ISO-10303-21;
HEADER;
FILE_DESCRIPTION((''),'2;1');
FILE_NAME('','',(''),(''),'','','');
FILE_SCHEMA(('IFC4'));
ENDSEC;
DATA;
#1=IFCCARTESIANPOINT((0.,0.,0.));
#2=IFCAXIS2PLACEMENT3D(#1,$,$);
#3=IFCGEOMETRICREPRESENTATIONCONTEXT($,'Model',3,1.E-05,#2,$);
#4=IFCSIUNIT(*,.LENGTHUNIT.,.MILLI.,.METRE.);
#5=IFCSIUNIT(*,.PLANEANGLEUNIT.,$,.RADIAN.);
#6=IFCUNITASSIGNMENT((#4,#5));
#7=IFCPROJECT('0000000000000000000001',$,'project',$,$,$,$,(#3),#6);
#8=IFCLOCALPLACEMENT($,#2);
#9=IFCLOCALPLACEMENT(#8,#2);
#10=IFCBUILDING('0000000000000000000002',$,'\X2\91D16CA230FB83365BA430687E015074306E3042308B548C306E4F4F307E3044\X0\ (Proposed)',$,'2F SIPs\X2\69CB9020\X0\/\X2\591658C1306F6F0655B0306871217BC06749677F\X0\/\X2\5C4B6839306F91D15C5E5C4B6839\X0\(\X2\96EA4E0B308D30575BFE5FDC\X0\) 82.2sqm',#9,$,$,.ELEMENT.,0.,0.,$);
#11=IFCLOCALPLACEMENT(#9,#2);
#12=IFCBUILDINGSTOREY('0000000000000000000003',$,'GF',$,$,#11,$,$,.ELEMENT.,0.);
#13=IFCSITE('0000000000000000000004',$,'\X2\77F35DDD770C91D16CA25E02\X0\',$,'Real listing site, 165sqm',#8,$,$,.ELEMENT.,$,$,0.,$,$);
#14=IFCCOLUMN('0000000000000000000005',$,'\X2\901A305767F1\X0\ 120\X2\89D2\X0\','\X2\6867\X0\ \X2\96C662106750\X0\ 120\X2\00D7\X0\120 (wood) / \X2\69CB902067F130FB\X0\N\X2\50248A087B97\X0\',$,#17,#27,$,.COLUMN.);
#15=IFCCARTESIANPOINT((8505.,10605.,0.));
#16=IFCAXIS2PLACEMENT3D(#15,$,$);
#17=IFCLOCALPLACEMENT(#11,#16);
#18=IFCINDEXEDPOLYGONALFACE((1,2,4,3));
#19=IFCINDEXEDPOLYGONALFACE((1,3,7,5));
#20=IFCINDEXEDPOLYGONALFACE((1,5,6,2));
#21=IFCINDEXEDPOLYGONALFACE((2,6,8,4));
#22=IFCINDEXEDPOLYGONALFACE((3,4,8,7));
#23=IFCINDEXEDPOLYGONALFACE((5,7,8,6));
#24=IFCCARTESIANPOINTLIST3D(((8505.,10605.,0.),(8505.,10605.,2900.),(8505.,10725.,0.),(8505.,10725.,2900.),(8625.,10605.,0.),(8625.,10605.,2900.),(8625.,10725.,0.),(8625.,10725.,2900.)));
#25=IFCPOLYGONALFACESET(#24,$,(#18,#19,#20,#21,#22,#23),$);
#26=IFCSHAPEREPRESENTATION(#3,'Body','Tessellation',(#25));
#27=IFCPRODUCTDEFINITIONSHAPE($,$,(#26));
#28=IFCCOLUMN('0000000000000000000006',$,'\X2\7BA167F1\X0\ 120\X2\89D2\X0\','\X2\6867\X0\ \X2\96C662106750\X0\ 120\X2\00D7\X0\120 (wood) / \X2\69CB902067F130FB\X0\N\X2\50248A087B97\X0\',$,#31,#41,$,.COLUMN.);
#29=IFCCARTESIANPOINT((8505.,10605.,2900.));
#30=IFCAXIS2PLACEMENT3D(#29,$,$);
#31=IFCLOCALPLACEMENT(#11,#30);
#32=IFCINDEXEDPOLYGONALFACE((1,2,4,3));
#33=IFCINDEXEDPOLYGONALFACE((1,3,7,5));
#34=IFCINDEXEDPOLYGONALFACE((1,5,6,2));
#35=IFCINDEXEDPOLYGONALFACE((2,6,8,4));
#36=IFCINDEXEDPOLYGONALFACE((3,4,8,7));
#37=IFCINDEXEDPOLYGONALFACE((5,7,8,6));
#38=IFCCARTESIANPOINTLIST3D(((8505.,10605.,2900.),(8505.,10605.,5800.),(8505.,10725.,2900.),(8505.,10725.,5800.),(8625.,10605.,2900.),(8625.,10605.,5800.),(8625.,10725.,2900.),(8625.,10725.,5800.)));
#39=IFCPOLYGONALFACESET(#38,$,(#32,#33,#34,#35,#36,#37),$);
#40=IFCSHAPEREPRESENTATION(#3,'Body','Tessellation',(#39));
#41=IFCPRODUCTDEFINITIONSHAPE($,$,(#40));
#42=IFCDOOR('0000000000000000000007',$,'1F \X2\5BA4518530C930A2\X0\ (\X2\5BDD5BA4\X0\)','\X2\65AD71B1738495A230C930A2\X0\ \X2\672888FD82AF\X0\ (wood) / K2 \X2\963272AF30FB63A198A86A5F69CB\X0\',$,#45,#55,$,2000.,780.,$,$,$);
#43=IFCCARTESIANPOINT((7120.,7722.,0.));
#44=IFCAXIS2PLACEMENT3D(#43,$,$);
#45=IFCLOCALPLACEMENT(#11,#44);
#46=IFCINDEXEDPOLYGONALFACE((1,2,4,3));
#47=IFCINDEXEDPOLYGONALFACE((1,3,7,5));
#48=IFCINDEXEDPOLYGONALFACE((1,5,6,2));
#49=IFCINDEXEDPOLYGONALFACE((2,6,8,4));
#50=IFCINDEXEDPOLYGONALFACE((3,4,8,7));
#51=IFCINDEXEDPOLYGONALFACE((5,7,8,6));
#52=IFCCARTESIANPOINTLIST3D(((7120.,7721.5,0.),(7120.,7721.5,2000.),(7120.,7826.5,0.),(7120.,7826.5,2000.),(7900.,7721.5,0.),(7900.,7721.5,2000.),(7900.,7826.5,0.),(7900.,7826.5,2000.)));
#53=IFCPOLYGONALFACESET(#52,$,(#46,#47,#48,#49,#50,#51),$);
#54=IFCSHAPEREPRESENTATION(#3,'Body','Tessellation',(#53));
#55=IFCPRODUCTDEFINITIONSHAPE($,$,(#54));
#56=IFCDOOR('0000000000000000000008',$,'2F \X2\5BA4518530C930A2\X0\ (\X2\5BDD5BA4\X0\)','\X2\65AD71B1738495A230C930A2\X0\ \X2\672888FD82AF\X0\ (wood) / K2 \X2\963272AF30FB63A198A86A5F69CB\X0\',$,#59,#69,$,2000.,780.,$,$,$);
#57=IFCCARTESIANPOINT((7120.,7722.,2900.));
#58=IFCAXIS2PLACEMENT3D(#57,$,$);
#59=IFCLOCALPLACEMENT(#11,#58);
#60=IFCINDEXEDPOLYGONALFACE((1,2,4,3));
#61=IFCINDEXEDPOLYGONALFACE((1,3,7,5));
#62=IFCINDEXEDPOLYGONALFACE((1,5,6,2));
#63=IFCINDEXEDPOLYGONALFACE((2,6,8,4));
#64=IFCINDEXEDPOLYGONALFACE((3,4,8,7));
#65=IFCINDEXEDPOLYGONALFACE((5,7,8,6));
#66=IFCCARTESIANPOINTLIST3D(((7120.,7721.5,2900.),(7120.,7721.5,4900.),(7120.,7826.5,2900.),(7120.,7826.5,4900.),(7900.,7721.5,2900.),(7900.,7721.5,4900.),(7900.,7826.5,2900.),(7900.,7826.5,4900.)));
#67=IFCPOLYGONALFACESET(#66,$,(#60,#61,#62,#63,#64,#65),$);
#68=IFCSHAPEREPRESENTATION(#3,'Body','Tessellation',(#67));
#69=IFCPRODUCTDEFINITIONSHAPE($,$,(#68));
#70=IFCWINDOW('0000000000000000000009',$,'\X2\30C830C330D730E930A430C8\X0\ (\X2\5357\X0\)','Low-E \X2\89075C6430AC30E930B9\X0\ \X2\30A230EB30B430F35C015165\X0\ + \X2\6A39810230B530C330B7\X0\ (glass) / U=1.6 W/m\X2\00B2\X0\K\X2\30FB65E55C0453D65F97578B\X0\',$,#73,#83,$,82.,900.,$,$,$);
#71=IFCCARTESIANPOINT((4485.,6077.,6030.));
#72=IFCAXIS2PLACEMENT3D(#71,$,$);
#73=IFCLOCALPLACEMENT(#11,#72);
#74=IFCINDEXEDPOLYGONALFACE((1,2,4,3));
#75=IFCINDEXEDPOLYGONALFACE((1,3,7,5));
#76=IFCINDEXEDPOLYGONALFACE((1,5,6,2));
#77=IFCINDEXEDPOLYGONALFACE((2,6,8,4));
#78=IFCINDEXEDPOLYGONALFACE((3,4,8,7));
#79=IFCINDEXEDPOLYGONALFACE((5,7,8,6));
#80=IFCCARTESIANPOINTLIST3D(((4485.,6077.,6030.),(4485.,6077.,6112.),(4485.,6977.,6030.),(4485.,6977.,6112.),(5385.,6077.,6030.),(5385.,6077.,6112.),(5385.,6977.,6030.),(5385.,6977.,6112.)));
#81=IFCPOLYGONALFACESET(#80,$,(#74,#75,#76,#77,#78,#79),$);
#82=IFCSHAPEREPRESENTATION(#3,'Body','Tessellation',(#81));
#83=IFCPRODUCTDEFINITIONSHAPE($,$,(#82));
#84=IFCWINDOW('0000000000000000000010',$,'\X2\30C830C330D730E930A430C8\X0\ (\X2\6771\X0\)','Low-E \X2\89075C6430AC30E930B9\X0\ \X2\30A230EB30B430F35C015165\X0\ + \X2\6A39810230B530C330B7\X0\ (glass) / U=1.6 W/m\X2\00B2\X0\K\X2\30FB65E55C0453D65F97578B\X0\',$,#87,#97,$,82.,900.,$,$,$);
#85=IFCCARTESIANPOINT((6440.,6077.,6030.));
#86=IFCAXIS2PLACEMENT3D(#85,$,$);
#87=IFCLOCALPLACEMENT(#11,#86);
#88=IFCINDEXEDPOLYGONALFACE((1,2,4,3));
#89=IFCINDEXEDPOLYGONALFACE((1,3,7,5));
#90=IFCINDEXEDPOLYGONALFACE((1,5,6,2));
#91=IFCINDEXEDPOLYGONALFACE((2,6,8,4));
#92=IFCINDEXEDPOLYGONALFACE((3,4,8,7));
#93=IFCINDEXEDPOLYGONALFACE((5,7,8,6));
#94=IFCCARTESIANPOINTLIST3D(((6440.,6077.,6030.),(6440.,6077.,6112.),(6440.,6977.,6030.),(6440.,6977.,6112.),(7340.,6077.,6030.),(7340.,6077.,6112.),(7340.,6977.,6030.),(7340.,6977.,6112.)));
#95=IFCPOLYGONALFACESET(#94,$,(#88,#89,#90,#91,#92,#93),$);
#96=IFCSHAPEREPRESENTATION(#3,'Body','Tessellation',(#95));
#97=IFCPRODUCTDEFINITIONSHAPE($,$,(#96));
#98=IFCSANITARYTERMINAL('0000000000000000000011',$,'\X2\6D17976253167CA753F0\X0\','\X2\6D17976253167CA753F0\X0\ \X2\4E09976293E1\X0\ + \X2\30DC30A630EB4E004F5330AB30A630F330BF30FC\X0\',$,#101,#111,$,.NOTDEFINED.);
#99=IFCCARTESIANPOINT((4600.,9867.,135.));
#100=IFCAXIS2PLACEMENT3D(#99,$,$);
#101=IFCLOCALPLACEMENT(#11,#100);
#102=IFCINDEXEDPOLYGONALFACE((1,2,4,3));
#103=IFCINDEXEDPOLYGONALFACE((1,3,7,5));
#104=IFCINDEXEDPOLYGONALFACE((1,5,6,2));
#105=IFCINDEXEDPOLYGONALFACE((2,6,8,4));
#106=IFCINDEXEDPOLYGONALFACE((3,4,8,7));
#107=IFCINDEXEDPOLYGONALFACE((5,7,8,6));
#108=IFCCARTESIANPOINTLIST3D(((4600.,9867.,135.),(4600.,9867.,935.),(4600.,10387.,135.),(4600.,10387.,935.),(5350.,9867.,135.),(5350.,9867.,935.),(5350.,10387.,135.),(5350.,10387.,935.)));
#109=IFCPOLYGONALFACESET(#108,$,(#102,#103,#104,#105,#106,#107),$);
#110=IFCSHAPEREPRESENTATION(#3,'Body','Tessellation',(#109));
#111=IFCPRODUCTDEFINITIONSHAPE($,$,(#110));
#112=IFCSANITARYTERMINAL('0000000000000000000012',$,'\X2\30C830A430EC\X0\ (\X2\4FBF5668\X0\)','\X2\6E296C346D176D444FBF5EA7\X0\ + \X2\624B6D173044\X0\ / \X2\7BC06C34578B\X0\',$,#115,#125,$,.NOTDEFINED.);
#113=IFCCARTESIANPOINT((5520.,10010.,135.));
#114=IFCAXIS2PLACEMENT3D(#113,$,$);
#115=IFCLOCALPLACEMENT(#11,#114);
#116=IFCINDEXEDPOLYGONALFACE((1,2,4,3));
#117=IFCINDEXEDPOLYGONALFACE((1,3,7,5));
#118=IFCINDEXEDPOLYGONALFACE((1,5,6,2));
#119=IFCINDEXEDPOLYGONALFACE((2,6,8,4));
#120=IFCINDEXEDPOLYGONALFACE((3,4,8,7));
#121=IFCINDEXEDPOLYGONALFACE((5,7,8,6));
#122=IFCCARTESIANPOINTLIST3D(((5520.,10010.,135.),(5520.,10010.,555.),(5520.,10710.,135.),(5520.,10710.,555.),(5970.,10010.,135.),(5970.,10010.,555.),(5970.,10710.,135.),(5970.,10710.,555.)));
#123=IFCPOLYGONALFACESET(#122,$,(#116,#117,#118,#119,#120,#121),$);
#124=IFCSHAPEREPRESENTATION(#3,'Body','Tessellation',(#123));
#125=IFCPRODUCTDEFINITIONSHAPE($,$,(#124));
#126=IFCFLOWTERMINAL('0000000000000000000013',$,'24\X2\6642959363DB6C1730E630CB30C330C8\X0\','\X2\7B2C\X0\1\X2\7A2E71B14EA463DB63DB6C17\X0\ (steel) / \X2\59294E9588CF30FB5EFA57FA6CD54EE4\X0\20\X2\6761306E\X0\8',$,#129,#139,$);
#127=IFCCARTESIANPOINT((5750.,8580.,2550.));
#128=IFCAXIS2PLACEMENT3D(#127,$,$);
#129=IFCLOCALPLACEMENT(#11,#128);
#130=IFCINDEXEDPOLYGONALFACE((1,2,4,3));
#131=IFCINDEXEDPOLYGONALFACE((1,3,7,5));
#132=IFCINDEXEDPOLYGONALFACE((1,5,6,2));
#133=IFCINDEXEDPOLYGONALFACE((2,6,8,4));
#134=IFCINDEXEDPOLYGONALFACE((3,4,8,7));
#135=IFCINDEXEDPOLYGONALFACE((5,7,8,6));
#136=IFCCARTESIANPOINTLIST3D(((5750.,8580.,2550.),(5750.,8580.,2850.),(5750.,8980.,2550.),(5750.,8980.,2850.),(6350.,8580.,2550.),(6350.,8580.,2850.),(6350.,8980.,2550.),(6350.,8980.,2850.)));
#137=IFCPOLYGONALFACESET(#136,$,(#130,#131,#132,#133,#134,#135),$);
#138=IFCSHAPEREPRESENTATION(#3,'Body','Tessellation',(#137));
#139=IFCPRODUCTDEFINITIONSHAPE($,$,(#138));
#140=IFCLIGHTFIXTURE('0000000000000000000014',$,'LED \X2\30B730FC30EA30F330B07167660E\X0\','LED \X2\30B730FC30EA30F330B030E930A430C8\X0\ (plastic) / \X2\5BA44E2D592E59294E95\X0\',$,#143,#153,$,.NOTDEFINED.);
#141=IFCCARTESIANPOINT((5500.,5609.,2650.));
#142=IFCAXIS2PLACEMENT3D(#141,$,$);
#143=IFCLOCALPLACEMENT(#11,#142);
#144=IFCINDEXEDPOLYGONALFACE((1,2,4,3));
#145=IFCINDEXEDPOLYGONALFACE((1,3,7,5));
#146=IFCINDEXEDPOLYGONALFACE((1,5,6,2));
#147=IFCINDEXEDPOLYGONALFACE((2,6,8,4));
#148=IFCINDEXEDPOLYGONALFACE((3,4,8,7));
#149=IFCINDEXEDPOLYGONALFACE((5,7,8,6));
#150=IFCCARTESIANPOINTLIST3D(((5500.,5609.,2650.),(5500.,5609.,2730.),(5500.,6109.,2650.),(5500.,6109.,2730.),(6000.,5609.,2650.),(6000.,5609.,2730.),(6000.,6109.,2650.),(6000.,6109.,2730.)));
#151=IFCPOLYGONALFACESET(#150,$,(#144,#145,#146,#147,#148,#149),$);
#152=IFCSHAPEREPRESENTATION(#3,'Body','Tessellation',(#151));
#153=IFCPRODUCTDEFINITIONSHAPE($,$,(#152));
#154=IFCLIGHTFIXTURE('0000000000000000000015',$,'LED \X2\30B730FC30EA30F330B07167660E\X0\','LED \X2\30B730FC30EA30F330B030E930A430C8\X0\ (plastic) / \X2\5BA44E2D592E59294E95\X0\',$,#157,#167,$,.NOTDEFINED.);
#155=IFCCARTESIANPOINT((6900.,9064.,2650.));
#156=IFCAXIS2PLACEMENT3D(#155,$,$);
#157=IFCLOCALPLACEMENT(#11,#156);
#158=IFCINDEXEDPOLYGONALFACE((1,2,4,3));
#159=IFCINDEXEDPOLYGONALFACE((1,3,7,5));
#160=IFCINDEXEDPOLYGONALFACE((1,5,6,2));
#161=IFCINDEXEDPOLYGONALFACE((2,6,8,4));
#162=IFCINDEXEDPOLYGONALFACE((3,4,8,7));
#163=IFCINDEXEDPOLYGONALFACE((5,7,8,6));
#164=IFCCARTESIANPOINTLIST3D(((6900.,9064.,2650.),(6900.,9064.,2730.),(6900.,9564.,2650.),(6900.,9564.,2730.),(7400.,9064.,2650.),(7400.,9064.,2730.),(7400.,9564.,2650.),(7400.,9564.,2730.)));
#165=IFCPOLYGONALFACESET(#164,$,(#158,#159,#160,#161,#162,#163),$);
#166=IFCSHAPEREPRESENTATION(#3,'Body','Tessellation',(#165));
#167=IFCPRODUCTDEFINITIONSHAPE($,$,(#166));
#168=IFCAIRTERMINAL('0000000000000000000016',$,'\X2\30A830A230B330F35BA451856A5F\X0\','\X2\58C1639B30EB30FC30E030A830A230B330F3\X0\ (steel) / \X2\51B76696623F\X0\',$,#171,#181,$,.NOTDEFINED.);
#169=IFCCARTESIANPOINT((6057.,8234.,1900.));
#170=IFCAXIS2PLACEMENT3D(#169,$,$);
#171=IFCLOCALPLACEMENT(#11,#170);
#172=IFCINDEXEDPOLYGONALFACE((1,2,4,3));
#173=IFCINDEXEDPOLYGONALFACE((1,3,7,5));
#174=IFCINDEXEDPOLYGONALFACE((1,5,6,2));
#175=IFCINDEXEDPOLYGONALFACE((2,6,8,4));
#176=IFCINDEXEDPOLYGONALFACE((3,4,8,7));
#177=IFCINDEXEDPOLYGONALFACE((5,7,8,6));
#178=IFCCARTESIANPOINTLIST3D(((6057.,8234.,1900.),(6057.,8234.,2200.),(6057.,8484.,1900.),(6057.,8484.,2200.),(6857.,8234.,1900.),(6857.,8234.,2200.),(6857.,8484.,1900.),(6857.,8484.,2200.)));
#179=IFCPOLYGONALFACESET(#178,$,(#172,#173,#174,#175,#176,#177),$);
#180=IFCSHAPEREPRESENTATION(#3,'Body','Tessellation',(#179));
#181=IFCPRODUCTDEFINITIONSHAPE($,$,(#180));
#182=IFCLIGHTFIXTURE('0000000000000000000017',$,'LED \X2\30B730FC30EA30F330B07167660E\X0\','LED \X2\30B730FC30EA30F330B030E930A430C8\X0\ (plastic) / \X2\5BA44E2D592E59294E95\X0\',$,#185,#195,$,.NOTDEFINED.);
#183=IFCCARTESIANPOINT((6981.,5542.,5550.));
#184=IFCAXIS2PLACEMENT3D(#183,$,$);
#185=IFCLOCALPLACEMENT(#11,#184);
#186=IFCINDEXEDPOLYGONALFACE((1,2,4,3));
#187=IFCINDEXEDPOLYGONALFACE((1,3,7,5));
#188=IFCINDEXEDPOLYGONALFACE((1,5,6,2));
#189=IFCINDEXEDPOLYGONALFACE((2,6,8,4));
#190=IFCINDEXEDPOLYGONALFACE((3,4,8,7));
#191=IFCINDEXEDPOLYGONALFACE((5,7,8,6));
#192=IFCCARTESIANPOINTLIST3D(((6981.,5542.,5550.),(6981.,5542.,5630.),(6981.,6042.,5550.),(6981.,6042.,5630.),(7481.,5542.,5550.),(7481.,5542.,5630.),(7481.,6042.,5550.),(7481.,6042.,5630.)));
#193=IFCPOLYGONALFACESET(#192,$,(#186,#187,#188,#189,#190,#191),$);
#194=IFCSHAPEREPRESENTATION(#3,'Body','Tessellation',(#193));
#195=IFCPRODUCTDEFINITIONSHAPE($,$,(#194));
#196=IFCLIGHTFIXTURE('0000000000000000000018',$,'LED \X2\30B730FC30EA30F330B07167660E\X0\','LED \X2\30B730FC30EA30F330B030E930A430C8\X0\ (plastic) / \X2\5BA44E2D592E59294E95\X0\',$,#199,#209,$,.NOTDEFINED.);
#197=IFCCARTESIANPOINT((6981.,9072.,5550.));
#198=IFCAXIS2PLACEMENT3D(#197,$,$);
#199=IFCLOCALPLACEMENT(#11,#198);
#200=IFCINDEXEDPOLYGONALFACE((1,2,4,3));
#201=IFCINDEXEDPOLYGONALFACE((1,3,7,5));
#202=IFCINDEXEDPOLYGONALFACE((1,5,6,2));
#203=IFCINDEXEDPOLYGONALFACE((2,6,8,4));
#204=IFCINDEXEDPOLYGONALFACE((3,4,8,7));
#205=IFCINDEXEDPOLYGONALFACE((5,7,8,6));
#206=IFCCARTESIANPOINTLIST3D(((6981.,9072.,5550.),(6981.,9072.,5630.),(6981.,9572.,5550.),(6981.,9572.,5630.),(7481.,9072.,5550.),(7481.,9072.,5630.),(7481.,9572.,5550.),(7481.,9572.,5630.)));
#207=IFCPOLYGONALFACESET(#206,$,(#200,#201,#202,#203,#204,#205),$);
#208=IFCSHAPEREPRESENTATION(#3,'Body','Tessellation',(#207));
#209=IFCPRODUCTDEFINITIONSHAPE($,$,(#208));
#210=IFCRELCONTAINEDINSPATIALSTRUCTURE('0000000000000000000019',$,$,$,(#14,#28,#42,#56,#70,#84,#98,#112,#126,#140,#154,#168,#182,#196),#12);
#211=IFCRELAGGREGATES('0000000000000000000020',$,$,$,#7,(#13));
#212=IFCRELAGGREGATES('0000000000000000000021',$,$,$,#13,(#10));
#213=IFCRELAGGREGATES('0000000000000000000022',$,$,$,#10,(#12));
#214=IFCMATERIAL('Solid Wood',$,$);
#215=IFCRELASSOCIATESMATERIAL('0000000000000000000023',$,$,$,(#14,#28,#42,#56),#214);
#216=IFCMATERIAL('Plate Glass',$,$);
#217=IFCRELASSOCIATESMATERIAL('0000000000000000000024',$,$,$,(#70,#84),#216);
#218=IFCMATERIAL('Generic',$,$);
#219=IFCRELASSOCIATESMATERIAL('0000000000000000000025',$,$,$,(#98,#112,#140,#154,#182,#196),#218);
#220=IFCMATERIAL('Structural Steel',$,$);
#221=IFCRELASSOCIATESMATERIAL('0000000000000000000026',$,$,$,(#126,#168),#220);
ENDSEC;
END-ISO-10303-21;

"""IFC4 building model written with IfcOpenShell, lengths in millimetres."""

from ifc_helpers import new_model, si_unit, frame, frame_2d, origin, place, context, project, spatial, rectangle, extrude, material, element, save


model = new_model("IFC4")

# Units and contexts
model_context = context("Model", 3, precision=1e-05, world=origin())
ifc_project = project(units=[si_unit("LENGTHUNIT", "METRE", prefix="MILLI"), si_unit("PLANEANGLEUNIT", "RADIAN")], contexts=[model_context])

# Site, building, storey
site_placement = place(None, origin())
site = spatial("IfcSite", under=ifc_project, at=site_placement, Name="石川県金沢市", ObjectType="Real listing site, 165sqm", CompositionType="ELEMENT", RefElevation=0.0)
building_placement = place(site_placement, origin())
building = spatial("IfcBuilding", under=site, at=building_placement, Name="金沢・茶室と縁側のある和の住まい (Proposed)", ObjectType="2F SIPs構造/外壁は漆喰と無節杉板/屋根は金属屋根(雪下ろし対応) 82.2sqm", CompositionType="ELEMENT", ElevationOfRefHeight=0.0, ElevationOfTerrain=0.0)
storey_placement = place(building_placement, origin())
storey = spatial("IfcBuildingStorey", under=building, at=storey_placement, Name="GF", CompositionType="ELEMENT", Elevation=0.0)

# Columns
ifc_material_1 = material(Name="Solid Wood")
column_1_placement = place(storey_placement, frame((8505.0, 10605.0, 0.0)))
element("IfcColumn", 1, at=column_1_placement, inside=storey, material=ifc_material_1, Name="通し柱 120角", Description="桧 集成材 120×120 (wood) / 構造柱・N値計算", PredefinedType="COLUMN", context=model_context, shape_type="SweptSolid", body=[
    extrude(rectangle(XDim=120.0, YDim=120.0, at=frame_2d((60.0, 60.0))), frame((8505.0, 10605.0, 0.0)), (0.0, 0.0, 1.0), 2900.0),
])
column_2_placement = place(storey_placement, frame((8505.0, 10605.0, 2900.0)))
element("IfcColumn", 2, at=column_2_placement, inside=storey, material=ifc_material_1, Name="管柱 120角", Description="桧 集成材 120×120 (wood) / 構造柱・N値計算", PredefinedType="COLUMN", context=model_context, shape_type="SweptSolid", body=[
    extrude(rectangle(XDim=120.0, YDim=120.0, at=frame_2d((60.0, 60.0))), frame((8505.0, 10605.0, 2900.0)), (0.0, 0.0, 1.0), 2900.0),
])

# Door
door_1_placement = place(storey_placement, frame((7120.0, 7722.0, 0.0)))
element("IfcDoor", 3, at=door_1_placement, inside=storey, material=ifc_material_1, Name="1F 室内ドア (寝室)", Description="断熱玄関ドア 木製芯 (wood) / K2 防犯・採風機構", OverallHeight=2000.0, OverallWidth=780.0, context=model_context, shape_type="SweptSolid", body=[
    extrude(rectangle(XDim=780.0, YDim=105.0, at=frame_2d((390.0, 52.0))), frame((7120.0, 7722.0, 0.0)), (0.0, 0.0, 1.0), 2000.0),
])

# Door
door_2_placement = place(storey_placement, frame((7120.0, 7722.0, 2900.0)))
element("IfcDoor", 4, at=door_2_placement, inside=storey, material=ifc_material_1, Name="2F 室内ドア (寝室)", Description="断熱玄関ドア 木製芯 (wood) / K2 防犯・採風機構", OverallHeight=2000.0, OverallWidth=780.0, context=model_context, shape_type="SweptSolid", body=[
    extrude(rectangle(XDim=780.0, YDim=105.0, at=frame_2d((390.0, 52.0))), frame((7120.0, 7722.0, 2900.0)), (0.0, 0.0, 1.0), 2000.0),
])

# Windows
ifc_material_2 = material(Name="Plate Glass")
window_1_placement = place(storey_placement, frame((4485.0, 6077.0, 6030.0)))
element("IfcWindow", 5, at=window_1_placement, inside=storey, material=ifc_material_2, Name="トップライト (南)", Description="Low-E 複層ガラス アルゴン封入 + 樹脂サッシ (glass) / U=1.6 W/m²K・日射取得型", OverallHeight=82.0, OverallWidth=900.0, context=model_context, shape_type="SweptSolid", body=[
    extrude(rectangle(XDim=900.0, YDim=900.0, at=frame_2d((450.0, 450.0))), frame((4485.0, 6077.0, 6030.0)), (0.0, 0.0, 1.0), 82.0),
])
window_2_placement = place(storey_placement, frame((6440.0, 6077.0, 6030.0)))
element("IfcWindow", 6, at=window_2_placement, inside=storey, material=ifc_material_2, Name="トップライト (東)", Description="Low-E 複層ガラス アルゴン封入 + 樹脂サッシ (glass) / U=1.6 W/m²K・日射取得型", OverallHeight=82.0, OverallWidth=900.0, context=model_context, shape_type="SweptSolid", body=[
    extrude(rectangle(XDim=900.0, YDim=900.0, at=frame_2d((450.0, 450.0))), frame((6440.0, 6077.0, 6030.0)), (0.0, 0.0, 1.0), 82.0),
])

# Sanitary terminals
ifc_material_3 = material(Name="Generic")
sanitary_terminal_1_placement = place(storey_placement, frame((4600.0, 9867.0, 135.0)))
element("IfcSanitaryTerminal", 7, at=sanitary_terminal_1_placement, inside=storey, material=ifc_material_3, Name="洗面化粧台", Description="洗面化粧台 三面鏡 + ボウル一体カウンター", PredefinedType="NOTDEFINED", context=model_context, shape_type="SweptSolid", body=[
    extrude(rectangle(XDim=750.0, YDim=520.0, at=frame_2d((375.0, 260.0))), frame((4600.0, 9867.0, 135.0)), (0.0, 0.0, 1.0), 800.0),
])
sanitary_terminal_2_placement = place(storey_placement, frame((5520.0, 10010.0, 135.0)))
element("IfcSanitaryTerminal", 8, at=sanitary_terminal_2_placement, inside=storey, material=ifc_material_3, Name="トイレ (便器)", Description="温水洗浄便座 + 手洗い / 節水型", PredefinedType="NOTDEFINED", context=model_context, shape_type="SweptSolid", body=[
    extrude(rectangle(XDim=450.0, YDim=700.0, at=frame_2d((225.0, 350.0))), frame((5520.0, 10010.0, 135.0)), (0.0, 0.0, 1.0), 420.0),
])

# Flow terminal
ifc_material_4 = material(Name="Structural Steel")
flow_terminal_placement = place(storey_placement, frame((5750.0, 8580.0, 2550.0)))
element("IfcFlowTerminal", 9, at=flow_terminal_placement, inside=storey, material=ifc_material_4, Name="24時間換気ユニット", Description="第1種熱交換換気 (steel) / 天井裏・建基法令20条の8", context=model_context, shape_type="SweptSolid", body=[
    extrude(rectangle(XDim=600.0, YDim=400.0, at=frame_2d((300.0, 200.0))), frame((5750.0, 8580.0, 2550.0)), (0.0, 0.0, 1.0), 300.0),
])

# Light fixtures
light_fixture_1_placement = place(storey_placement, frame((5500.0, 5609.0, 2650.0)))
element("IfcLightFixture", 10, at=light_fixture_1_placement, inside=storey, material=ifc_material_3, Name="LED シーリング照明", Description="LED シーリングライト (plastic) / 室中央天井", PredefinedType="NOTDEFINED", context=model_context, shape_type="SweptSolid", body=[
    extrude(rectangle(XDim=500.0, YDim=500.0, at=frame_2d((250.0, 250.0))), frame((5500.0, 5609.0, 2650.0)), (0.0, 0.0, 1.0), 80.0),
])
light_fixture_2_placement = place(storey_placement, frame((6900.0, 9064.0, 2650.0)))
element("IfcLightFixture", 11, at=light_fixture_2_placement, inside=storey, material=ifc_material_3, Name="LED シーリング照明", Description="LED シーリングライト (plastic) / 室中央天井", PredefinedType="NOTDEFINED", context=model_context, shape_type="SweptSolid", body=[
    extrude(rectangle(XDim=500.0, YDim=500.0, at=frame_2d((250.0, 250.0))), frame((6900.0, 9064.0, 2650.0)), (0.0, 0.0, 1.0), 80.0),
])

# Air terminal
air_terminal_placement = place(storey_placement, frame((6057.0, 8234.0, 1900.0)))
element("IfcAirTerminal", 12, at=air_terminal_placement, inside=storey, material=ifc_material_4, Name="エアコン室内機", Description="壁掛ルームエアコン (steel) / 冷暖房", PredefinedType="NOTDEFINED", context=model_context, shape_type="SweptSolid", body=[
    extrude(rectangle(XDim=800.0, YDim=250.0, at=frame_2d((400.0, 125.0))), frame((6057.0, 8234.0, 1900.0)), (0.0, 0.0, 1.0), 300.0),
])

# Light fixtures
light_fixture_3_placement = place(storey_placement, frame((6981.0, 5542.0, 5550.0)))
element("IfcLightFixture", 13, at=light_fixture_3_placement, inside=storey, material=ifc_material_3, Name="LED シーリング照明", Description="LED シーリングライト (plastic) / 室中央天井", PredefinedType="NOTDEFINED", context=model_context, shape_type="SweptSolid", body=[
    extrude(rectangle(XDim=500.0, YDim=500.0, at=frame_2d((250.0, 250.0))), frame((6981.0, 5542.0, 5550.0)), (0.0, 0.0, 1.0), 80.0),
])
light_fixture_4_placement = place(storey_placement, frame((6981.0, 9072.0, 5550.0)))
element("IfcLightFixture", 14, at=light_fixture_4_placement, inside=storey, material=ifc_material_3, Name="LED シーリング照明", Description="LED シーリングライト (plastic) / 室中央天井", PredefinedType="NOTDEFINED", context=model_context, shape_type="SweptSolid", body=[
    extrude(rectangle(XDim=500.0, YDim=500.0, at=frame_2d((250.0, 250.0))), frame((6981.0, 9072.0, 5550.0)), (0.0, 0.0, 1.0), 80.0),
])

save(model, "model.ifc")
